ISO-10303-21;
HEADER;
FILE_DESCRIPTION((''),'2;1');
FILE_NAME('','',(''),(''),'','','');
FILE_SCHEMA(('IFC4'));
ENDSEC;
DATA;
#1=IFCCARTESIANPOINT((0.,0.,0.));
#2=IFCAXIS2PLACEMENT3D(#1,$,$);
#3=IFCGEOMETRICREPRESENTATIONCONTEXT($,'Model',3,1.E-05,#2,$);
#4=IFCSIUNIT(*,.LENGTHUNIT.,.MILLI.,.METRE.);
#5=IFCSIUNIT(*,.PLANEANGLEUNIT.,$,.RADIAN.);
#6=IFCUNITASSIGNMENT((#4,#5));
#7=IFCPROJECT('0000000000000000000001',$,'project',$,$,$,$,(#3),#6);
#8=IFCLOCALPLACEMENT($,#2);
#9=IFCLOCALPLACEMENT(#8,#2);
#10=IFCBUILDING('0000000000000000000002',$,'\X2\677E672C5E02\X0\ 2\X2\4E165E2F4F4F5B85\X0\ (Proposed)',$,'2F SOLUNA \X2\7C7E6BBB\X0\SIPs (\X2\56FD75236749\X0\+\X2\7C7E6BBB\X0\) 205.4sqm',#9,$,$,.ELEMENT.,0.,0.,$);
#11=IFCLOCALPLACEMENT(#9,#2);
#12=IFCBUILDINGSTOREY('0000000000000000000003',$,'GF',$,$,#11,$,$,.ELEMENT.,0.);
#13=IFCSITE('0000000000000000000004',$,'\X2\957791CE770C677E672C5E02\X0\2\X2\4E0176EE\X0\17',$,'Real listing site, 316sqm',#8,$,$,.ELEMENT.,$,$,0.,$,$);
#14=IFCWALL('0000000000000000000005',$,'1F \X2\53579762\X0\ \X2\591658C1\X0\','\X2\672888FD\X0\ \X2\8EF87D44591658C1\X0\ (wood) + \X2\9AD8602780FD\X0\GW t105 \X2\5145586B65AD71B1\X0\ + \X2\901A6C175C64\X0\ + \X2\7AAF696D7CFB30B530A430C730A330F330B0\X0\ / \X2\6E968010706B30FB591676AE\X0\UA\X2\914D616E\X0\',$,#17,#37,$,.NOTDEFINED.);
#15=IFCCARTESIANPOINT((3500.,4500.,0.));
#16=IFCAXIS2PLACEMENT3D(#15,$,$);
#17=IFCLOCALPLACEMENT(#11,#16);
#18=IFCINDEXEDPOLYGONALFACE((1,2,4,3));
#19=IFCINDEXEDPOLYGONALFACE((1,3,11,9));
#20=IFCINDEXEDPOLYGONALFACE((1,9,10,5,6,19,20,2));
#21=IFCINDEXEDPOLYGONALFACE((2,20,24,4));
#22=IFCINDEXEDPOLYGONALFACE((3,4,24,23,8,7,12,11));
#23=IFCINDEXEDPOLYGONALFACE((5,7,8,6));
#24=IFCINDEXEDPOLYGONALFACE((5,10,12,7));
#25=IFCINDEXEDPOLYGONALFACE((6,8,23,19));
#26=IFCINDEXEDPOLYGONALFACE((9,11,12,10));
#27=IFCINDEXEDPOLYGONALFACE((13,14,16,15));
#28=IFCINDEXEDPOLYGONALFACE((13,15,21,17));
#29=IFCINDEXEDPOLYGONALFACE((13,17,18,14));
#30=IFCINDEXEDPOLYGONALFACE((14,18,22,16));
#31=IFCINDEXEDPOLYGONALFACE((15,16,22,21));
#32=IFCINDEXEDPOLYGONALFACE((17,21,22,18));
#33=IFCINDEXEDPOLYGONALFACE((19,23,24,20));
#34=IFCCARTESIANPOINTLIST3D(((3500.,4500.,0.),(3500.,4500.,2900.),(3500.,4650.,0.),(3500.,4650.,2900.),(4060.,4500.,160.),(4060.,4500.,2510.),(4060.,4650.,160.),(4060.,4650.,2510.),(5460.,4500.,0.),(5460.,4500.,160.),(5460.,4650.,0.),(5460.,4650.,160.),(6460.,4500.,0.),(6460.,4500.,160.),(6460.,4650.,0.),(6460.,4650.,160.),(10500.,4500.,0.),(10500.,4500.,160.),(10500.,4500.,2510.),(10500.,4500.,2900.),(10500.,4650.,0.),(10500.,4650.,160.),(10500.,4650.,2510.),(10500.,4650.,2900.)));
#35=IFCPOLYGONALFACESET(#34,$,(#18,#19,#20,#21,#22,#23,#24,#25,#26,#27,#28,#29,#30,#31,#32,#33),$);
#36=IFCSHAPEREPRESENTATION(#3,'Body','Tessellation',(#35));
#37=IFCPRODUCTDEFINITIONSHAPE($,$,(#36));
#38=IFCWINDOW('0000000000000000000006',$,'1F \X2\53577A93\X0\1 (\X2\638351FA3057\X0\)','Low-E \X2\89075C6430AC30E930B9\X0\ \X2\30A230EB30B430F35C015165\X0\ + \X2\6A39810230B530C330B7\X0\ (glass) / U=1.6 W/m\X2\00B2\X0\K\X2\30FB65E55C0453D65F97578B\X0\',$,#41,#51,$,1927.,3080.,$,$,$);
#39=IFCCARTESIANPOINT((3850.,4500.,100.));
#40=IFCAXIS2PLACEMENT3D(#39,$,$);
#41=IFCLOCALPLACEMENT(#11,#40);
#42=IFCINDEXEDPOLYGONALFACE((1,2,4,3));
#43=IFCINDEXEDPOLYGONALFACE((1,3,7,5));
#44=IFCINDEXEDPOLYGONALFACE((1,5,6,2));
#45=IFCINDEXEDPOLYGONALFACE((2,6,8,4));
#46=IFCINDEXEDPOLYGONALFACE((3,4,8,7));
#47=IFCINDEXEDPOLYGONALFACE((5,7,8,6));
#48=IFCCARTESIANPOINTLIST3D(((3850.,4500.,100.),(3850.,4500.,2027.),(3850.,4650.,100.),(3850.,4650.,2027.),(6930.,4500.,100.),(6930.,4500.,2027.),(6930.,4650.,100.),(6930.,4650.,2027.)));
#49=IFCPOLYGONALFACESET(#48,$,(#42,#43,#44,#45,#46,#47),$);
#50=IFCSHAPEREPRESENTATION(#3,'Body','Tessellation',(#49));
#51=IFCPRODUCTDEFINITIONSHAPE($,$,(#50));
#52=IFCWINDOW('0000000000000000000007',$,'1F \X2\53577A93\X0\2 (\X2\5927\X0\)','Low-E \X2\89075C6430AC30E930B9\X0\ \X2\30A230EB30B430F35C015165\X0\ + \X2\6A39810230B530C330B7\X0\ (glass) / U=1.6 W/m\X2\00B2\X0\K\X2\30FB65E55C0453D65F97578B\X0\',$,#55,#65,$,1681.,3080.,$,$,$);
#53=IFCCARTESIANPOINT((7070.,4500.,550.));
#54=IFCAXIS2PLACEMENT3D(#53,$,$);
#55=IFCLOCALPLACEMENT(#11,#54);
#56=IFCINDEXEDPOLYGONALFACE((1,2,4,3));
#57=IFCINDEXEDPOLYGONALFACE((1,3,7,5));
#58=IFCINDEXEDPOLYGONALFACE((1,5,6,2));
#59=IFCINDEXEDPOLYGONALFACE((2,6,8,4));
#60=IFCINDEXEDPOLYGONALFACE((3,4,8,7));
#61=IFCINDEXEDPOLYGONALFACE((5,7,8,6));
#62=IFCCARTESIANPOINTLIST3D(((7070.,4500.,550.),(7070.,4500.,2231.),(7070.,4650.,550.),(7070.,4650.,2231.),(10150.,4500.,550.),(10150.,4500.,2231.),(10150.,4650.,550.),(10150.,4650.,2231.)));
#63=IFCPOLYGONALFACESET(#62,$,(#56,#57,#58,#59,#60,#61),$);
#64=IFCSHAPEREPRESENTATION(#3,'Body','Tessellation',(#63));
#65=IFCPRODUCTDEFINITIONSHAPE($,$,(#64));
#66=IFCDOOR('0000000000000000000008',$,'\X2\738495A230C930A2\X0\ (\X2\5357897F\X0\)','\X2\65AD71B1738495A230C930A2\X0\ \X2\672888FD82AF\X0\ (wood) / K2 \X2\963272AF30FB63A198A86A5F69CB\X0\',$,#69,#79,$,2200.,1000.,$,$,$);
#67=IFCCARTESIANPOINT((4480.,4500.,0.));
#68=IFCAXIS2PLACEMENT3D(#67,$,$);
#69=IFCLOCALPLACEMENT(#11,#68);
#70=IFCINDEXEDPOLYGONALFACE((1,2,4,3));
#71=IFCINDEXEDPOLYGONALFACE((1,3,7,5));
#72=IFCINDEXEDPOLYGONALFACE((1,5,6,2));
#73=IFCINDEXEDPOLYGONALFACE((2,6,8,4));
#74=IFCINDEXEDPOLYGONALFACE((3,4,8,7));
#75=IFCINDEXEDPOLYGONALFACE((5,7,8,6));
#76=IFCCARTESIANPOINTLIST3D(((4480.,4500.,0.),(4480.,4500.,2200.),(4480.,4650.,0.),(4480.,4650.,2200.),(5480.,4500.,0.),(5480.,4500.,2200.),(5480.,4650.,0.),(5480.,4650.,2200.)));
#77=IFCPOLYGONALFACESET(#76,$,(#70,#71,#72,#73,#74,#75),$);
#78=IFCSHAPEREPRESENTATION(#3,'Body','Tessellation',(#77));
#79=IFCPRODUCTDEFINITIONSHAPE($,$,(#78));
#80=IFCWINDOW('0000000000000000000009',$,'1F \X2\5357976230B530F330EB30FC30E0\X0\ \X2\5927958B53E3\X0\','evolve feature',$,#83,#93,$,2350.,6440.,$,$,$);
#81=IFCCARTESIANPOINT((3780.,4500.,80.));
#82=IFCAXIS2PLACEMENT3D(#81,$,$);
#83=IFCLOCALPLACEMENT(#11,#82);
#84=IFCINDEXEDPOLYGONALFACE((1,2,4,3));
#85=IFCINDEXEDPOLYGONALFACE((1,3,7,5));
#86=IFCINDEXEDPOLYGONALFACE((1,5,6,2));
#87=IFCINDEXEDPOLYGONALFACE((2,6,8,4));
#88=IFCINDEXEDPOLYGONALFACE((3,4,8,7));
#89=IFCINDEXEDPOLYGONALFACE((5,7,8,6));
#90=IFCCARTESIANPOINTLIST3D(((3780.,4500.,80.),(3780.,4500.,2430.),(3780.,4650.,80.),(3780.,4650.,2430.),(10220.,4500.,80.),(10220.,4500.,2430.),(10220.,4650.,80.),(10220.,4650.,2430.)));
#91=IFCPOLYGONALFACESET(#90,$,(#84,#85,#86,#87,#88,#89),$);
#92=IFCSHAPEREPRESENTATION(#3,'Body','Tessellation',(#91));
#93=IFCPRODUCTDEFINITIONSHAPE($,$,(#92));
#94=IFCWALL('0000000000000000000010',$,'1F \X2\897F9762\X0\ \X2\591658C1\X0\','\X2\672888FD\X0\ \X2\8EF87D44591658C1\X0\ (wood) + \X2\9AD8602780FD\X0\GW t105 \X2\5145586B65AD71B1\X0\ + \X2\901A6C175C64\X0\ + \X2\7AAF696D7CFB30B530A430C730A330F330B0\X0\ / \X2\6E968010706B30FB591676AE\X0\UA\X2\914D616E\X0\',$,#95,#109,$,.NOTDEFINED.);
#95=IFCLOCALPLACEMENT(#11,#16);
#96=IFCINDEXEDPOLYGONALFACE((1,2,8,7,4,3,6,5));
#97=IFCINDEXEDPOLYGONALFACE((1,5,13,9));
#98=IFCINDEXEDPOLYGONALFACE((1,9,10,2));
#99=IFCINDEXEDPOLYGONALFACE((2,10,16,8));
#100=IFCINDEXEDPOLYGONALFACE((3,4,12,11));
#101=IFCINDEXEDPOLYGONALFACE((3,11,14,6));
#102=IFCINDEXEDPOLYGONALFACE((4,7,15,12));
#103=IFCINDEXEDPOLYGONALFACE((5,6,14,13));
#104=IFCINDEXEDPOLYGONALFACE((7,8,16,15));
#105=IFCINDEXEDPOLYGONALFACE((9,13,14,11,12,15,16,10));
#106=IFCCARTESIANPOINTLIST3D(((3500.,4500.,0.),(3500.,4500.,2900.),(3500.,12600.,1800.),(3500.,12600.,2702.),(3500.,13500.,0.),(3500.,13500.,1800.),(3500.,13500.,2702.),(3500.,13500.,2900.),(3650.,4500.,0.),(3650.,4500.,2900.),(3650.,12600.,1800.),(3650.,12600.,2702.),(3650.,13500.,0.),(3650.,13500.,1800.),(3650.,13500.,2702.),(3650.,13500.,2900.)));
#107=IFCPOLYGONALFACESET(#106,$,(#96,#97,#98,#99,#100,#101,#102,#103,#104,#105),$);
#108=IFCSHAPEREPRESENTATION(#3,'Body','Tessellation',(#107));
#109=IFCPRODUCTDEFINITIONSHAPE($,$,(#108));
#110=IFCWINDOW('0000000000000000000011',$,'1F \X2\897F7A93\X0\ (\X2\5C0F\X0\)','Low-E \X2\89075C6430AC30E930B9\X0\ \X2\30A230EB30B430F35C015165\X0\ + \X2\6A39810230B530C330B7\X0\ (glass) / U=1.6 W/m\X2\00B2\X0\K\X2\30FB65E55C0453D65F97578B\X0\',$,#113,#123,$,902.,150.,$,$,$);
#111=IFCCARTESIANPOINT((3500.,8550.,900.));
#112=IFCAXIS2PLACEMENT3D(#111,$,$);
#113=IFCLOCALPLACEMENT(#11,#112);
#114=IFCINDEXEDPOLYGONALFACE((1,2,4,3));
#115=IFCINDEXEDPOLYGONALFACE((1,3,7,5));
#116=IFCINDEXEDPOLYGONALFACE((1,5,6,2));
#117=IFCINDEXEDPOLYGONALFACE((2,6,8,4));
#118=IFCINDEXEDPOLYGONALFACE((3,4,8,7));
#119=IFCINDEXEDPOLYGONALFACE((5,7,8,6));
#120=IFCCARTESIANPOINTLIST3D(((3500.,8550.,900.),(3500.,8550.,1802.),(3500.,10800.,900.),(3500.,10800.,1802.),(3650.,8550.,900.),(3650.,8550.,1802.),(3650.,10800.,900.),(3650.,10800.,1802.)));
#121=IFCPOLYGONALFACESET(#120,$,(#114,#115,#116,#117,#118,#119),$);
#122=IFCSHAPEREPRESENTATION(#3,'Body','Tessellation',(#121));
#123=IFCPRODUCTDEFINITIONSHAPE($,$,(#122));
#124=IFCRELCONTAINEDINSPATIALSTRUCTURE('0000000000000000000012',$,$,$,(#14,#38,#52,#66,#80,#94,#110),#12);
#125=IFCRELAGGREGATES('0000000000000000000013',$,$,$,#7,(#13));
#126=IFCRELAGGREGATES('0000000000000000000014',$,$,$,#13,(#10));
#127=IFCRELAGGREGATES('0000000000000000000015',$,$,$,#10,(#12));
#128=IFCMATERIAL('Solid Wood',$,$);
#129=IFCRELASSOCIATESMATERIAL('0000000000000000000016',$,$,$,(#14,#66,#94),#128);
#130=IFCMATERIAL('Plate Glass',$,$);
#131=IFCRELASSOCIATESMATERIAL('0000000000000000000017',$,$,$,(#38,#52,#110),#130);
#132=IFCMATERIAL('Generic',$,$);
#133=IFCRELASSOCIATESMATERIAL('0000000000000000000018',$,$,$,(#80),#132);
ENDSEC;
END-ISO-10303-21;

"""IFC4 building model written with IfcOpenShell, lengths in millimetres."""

from ifc_helpers import new_model, si_unit, frame, frame_2d, origin, place, context, project, spatial, rectangle, extrude, material, element, fill, save


model = new_model("IFC4")

# Units and contexts
model_context = context("Model", 3, precision=1e-05, world=origin())
ifc_project = project(units=[si_unit("LENGTHUNIT", "METRE", prefix="MILLI"), si_unit("PLANEANGLEUNIT", "RADIAN")], contexts=[model_context])

# Site, building, storey
site_placement = place(None, origin())
site = spatial("IfcSite", under=ifc_project, at=site_placement, Name="長野県松本市2丁目17", ObjectType="Real listing site, 316sqm", CompositionType="ELEMENT", RefElevation=0.0)
building_placement = place(site_placement, origin())
building = spatial("IfcBuilding", under=site, at=building_placement, Name="松本市 2世帯住宅 (Proposed)", ObjectType="2F SOLUNA 籾殻SIPs (国産杉+籾殻) 205.4sqm", CompositionType="ELEMENT", ElevationOfRefHeight=0.0, ElevationOfTerrain=0.0)
storey_placement = place(building_placement, origin())
storey = spatial("IfcBuildingStorey", under=building, at=storey_placement, Name="GF", CompositionType="ELEMENT", Elevation=0.0)

# Shared definitions
ifc_material_1 = material(Name="Solid Wood")
ifc_material_2 = material(Name="Generic")

# Wall, openings, windows, door
wall_1_placement = place(storey_placement, frame((3500.0, 4500.0, 0.0)))
wall_1 = element("IfcWall", 1, at=wall_1_placement, inside=storey, material=ifc_material_1, Name="1F 南面 外壁", Description="木製 軸組外壁 (wood) + 高性能GW t105 充填断熱 + 通気層 + 窯業系サイディング / 準耐火・外皮UA配慮", PredefinedType="NOTDEFINED", context=model_context, shape_type="SweptSolid", body=[
    extrude(rectangle(XDim=7000.0, YDim=150.0, at=frame_2d((3500.0, 75.0))), frame((3500.0, 4500.0, 0.0)), (0.0, 0.0, 1.0), 2900.0),
])
opening_1_placement = place(storey_placement, frame((3850.0, 4500.0, 100.0)))
opening_1 = element("IfcOpeningElement", 2, at=opening_1_placement, cuts=wall_1, PredefinedType="NOTDEFINED", context=model_context, shape_type="SweptSolid", body=[
    extrude(rectangle(XDim=3080.0, YDim=150.0, at=frame_2d((1540.0, 75.0))), frame((3850.0, 4500.0, 100.0)), (0.0, 0.0, 1.0), 1927.0),
])
opening_2_placement = place(storey_placement, frame((7070.0, 4500.0, 550.0)))
opening_2 = element("IfcOpeningElement", 3, at=opening_2_placement, cuts=wall_1, PredefinedType="NOTDEFINED", context=model_context, shape_type="SweptSolid", body=[
    extrude(rectangle(XDim=3080.0, YDim=150.0, at=frame_2d((1540.0, 75.0))), frame((7070.0, 4500.0, 550.0)), (0.0, 0.0, 1.0), 1681.0),
])
opening_3_placement = place(storey_placement, frame((4480.0, 4500.0, 0.0)))
opening_3 = element("IfcOpeningElement", 4, at=opening_3_placement, cuts=wall_1, PredefinedType="NOTDEFINED", context=model_context, shape_type="SweptSolid", body=[
    extrude(rectangle(XDim=1000.0, YDim=150.0, at=frame_2d((500.0, 75.0))), frame((4480.0, 4500.0, 0.0)), (0.0, 0.0, 1.0), 2200.0),
])
opening_4_placement = place(storey_placement, frame((3780.0, 4500.0, 80.0)))
opening_4 = element("IfcOpeningElement", 5, at=opening_4_placement, cuts=wall_1, PredefinedType="NOTDEFINED", context=model_context, shape_type="SweptSolid", body=[
    extrude(rectangle(XDim=6440.0, YDim=150.0, at=frame_2d((3220.0, 75.0))), frame((3780.0, 4500.0, 80.0)), (0.0, 0.0, 1.0), 2350.0),
])
ifc_material_3 = material(Name="Plate Glass")
window_1_placement = place(storey_placement, frame((3850.0, 4500.0, 100.0)))
window_1 = element("IfcWindow", 6, at=window_1_placement, inside=storey, material=ifc_material_3, Name="1F 南窓1 (掃出し)", Description="Low-E 複層ガラス アルゴン封入 + 樹脂サッシ (glass) / U=1.6 W/m²K・日射取得型", OverallHeight=1927.0, OverallWidth=3080.0, context=model_context, shape_type="SweptSolid", body=[
    extrude(rectangle(XDim=3080.0, YDim=150.0, at=frame_2d((1540.0, 75.0))), frame((3850.0, 4500.0, 100.0)), (0.0, 0.0, 1.0), 1927.0),
])
fill(opening_1, window_1)
window_2_placement = place(storey_placement, frame((7070.0, 4500.0, 550.0)))
window_2 = element("IfcWindow", 7, at=window_2_placement, inside=storey, material=ifc_material_3, Name="1F 南窓2 (大)", Description="Low-E 複層ガラス アルゴン封入 + 樹脂サッシ (glass) / U=1.6 W/m²K・日射取得型", OverallHeight=1681.0, OverallWidth=3080.0, context=model_context, shape_type="SweptSolid", body=[
    extrude(rectangle(XDim=3080.0, YDim=150.0, at=frame_2d((1540.0, 75.0))), frame((7070.0, 4500.0, 550.0)), (0.0, 0.0, 1.0), 1681.0),
])
fill(opening_2, window_2)
door_placement = place(storey_placement, frame((4480.0, 4500.0, 0.0)))
door = element("IfcDoor", 8, at=door_placement, inside=storey, material=ifc_material_1, Name="玄関ドア (南西)", Description="断熱玄関ドア 木製芯 (wood) / K2 防犯・採風機構", OverallHeight=2200.0, OverallWidth=1000.0, context=model_context, shape_type="SweptSolid", body=[
    extrude(rectangle(XDim=1000.0, YDim=150.0, at=frame_2d((500.0, 75.0))), frame((4480.0, 4500.0, 0.0)), (0.0, 0.0, 1.0), 2200.0),
])
fill(opening_3, door)
window_3_placement = place(storey_placement, frame((3780.0, 4500.0, 80.0)))
window_3 = element("IfcWindow", 9, at=window_3_placement, inside=storey, material=ifc_material_2, Name="1F 南面サンルーム 大開口", Description="evolve feature", OverallHeight=2350.0, OverallWidth=6440.0, context=model_context, shape_type="SweptSolid", body=[
    extrude(rectangle(XDim=6440.0, YDim=150.0, at=frame_2d((3220.0, 75.0))), frame((3780.0, 4500.0, 80.0)), (0.0, 0.0, 1.0), 2350.0),
])
fill(opening_4, window_3)

# Wall, opening, window
wall_2_placement = place(storey_placement, frame((3500.0, 4500.0, 0.0)))
wall_2 = element("IfcWall", 10, at=wall_2_placement, inside=storey, material=ifc_material_1, Name="1F 西面 外壁", Description="木製 軸組外壁 (wood) + 高性能GW t105 充填断熱 + 通気層 + 窯業系サイディング / 準耐火・外皮UA配慮", PredefinedType="NOTDEFINED", context=model_context, shape_type="SweptSolid", body=[
    extrude(rectangle(XDim=150.0, YDim=9000.0, at=frame_2d((75.0, 4500.0))), frame((3500.0, 4500.0, 0.0)), (0.0, 0.0, 1.0), 2900.0),
])
opening_5_placement = place(storey_placement, frame((3500.0, 8550.0, 900.0)))
opening_5 = element("IfcOpeningElement", 11, at=opening_5_placement, cuts=wall_2, PredefinedType="NOTDEFINED", context=model_context, shape_type="SweptSolid", body=[
    extrude(rectangle(XDim=150.0, YDim=2250.0, at=frame_2d((75.0, 1125.0))), frame((3500.0, 8550.0, 900.0)), (0.0, 0.0, 1.0), 902.0),
])
window_4_placement = place(storey_placement, frame((3500.0, 8550.0, 900.0)))
window_4 = element("IfcWindow", 12, at=window_4_placement, inside=storey, material=ifc_material_3, Name="1F 西窓 (小)", Description="Low-E 複層ガラス アルゴン封入 + 樹脂サッシ (glass) / U=1.6 W/m²K・日射取得型", OverallHeight=902.0, OverallWidth=150.0, context=model_context, shape_type="SweptSolid", body=[
    extrude(rectangle(XDim=150.0, YDim=2250.0, at=frame_2d((75.0, 1125.0))), frame((3500.0, 8550.0, 900.0)), (0.0, 0.0, 1.0), 902.0),
])
fill(opening_5, window_4)

save(model, "model.ifc")
